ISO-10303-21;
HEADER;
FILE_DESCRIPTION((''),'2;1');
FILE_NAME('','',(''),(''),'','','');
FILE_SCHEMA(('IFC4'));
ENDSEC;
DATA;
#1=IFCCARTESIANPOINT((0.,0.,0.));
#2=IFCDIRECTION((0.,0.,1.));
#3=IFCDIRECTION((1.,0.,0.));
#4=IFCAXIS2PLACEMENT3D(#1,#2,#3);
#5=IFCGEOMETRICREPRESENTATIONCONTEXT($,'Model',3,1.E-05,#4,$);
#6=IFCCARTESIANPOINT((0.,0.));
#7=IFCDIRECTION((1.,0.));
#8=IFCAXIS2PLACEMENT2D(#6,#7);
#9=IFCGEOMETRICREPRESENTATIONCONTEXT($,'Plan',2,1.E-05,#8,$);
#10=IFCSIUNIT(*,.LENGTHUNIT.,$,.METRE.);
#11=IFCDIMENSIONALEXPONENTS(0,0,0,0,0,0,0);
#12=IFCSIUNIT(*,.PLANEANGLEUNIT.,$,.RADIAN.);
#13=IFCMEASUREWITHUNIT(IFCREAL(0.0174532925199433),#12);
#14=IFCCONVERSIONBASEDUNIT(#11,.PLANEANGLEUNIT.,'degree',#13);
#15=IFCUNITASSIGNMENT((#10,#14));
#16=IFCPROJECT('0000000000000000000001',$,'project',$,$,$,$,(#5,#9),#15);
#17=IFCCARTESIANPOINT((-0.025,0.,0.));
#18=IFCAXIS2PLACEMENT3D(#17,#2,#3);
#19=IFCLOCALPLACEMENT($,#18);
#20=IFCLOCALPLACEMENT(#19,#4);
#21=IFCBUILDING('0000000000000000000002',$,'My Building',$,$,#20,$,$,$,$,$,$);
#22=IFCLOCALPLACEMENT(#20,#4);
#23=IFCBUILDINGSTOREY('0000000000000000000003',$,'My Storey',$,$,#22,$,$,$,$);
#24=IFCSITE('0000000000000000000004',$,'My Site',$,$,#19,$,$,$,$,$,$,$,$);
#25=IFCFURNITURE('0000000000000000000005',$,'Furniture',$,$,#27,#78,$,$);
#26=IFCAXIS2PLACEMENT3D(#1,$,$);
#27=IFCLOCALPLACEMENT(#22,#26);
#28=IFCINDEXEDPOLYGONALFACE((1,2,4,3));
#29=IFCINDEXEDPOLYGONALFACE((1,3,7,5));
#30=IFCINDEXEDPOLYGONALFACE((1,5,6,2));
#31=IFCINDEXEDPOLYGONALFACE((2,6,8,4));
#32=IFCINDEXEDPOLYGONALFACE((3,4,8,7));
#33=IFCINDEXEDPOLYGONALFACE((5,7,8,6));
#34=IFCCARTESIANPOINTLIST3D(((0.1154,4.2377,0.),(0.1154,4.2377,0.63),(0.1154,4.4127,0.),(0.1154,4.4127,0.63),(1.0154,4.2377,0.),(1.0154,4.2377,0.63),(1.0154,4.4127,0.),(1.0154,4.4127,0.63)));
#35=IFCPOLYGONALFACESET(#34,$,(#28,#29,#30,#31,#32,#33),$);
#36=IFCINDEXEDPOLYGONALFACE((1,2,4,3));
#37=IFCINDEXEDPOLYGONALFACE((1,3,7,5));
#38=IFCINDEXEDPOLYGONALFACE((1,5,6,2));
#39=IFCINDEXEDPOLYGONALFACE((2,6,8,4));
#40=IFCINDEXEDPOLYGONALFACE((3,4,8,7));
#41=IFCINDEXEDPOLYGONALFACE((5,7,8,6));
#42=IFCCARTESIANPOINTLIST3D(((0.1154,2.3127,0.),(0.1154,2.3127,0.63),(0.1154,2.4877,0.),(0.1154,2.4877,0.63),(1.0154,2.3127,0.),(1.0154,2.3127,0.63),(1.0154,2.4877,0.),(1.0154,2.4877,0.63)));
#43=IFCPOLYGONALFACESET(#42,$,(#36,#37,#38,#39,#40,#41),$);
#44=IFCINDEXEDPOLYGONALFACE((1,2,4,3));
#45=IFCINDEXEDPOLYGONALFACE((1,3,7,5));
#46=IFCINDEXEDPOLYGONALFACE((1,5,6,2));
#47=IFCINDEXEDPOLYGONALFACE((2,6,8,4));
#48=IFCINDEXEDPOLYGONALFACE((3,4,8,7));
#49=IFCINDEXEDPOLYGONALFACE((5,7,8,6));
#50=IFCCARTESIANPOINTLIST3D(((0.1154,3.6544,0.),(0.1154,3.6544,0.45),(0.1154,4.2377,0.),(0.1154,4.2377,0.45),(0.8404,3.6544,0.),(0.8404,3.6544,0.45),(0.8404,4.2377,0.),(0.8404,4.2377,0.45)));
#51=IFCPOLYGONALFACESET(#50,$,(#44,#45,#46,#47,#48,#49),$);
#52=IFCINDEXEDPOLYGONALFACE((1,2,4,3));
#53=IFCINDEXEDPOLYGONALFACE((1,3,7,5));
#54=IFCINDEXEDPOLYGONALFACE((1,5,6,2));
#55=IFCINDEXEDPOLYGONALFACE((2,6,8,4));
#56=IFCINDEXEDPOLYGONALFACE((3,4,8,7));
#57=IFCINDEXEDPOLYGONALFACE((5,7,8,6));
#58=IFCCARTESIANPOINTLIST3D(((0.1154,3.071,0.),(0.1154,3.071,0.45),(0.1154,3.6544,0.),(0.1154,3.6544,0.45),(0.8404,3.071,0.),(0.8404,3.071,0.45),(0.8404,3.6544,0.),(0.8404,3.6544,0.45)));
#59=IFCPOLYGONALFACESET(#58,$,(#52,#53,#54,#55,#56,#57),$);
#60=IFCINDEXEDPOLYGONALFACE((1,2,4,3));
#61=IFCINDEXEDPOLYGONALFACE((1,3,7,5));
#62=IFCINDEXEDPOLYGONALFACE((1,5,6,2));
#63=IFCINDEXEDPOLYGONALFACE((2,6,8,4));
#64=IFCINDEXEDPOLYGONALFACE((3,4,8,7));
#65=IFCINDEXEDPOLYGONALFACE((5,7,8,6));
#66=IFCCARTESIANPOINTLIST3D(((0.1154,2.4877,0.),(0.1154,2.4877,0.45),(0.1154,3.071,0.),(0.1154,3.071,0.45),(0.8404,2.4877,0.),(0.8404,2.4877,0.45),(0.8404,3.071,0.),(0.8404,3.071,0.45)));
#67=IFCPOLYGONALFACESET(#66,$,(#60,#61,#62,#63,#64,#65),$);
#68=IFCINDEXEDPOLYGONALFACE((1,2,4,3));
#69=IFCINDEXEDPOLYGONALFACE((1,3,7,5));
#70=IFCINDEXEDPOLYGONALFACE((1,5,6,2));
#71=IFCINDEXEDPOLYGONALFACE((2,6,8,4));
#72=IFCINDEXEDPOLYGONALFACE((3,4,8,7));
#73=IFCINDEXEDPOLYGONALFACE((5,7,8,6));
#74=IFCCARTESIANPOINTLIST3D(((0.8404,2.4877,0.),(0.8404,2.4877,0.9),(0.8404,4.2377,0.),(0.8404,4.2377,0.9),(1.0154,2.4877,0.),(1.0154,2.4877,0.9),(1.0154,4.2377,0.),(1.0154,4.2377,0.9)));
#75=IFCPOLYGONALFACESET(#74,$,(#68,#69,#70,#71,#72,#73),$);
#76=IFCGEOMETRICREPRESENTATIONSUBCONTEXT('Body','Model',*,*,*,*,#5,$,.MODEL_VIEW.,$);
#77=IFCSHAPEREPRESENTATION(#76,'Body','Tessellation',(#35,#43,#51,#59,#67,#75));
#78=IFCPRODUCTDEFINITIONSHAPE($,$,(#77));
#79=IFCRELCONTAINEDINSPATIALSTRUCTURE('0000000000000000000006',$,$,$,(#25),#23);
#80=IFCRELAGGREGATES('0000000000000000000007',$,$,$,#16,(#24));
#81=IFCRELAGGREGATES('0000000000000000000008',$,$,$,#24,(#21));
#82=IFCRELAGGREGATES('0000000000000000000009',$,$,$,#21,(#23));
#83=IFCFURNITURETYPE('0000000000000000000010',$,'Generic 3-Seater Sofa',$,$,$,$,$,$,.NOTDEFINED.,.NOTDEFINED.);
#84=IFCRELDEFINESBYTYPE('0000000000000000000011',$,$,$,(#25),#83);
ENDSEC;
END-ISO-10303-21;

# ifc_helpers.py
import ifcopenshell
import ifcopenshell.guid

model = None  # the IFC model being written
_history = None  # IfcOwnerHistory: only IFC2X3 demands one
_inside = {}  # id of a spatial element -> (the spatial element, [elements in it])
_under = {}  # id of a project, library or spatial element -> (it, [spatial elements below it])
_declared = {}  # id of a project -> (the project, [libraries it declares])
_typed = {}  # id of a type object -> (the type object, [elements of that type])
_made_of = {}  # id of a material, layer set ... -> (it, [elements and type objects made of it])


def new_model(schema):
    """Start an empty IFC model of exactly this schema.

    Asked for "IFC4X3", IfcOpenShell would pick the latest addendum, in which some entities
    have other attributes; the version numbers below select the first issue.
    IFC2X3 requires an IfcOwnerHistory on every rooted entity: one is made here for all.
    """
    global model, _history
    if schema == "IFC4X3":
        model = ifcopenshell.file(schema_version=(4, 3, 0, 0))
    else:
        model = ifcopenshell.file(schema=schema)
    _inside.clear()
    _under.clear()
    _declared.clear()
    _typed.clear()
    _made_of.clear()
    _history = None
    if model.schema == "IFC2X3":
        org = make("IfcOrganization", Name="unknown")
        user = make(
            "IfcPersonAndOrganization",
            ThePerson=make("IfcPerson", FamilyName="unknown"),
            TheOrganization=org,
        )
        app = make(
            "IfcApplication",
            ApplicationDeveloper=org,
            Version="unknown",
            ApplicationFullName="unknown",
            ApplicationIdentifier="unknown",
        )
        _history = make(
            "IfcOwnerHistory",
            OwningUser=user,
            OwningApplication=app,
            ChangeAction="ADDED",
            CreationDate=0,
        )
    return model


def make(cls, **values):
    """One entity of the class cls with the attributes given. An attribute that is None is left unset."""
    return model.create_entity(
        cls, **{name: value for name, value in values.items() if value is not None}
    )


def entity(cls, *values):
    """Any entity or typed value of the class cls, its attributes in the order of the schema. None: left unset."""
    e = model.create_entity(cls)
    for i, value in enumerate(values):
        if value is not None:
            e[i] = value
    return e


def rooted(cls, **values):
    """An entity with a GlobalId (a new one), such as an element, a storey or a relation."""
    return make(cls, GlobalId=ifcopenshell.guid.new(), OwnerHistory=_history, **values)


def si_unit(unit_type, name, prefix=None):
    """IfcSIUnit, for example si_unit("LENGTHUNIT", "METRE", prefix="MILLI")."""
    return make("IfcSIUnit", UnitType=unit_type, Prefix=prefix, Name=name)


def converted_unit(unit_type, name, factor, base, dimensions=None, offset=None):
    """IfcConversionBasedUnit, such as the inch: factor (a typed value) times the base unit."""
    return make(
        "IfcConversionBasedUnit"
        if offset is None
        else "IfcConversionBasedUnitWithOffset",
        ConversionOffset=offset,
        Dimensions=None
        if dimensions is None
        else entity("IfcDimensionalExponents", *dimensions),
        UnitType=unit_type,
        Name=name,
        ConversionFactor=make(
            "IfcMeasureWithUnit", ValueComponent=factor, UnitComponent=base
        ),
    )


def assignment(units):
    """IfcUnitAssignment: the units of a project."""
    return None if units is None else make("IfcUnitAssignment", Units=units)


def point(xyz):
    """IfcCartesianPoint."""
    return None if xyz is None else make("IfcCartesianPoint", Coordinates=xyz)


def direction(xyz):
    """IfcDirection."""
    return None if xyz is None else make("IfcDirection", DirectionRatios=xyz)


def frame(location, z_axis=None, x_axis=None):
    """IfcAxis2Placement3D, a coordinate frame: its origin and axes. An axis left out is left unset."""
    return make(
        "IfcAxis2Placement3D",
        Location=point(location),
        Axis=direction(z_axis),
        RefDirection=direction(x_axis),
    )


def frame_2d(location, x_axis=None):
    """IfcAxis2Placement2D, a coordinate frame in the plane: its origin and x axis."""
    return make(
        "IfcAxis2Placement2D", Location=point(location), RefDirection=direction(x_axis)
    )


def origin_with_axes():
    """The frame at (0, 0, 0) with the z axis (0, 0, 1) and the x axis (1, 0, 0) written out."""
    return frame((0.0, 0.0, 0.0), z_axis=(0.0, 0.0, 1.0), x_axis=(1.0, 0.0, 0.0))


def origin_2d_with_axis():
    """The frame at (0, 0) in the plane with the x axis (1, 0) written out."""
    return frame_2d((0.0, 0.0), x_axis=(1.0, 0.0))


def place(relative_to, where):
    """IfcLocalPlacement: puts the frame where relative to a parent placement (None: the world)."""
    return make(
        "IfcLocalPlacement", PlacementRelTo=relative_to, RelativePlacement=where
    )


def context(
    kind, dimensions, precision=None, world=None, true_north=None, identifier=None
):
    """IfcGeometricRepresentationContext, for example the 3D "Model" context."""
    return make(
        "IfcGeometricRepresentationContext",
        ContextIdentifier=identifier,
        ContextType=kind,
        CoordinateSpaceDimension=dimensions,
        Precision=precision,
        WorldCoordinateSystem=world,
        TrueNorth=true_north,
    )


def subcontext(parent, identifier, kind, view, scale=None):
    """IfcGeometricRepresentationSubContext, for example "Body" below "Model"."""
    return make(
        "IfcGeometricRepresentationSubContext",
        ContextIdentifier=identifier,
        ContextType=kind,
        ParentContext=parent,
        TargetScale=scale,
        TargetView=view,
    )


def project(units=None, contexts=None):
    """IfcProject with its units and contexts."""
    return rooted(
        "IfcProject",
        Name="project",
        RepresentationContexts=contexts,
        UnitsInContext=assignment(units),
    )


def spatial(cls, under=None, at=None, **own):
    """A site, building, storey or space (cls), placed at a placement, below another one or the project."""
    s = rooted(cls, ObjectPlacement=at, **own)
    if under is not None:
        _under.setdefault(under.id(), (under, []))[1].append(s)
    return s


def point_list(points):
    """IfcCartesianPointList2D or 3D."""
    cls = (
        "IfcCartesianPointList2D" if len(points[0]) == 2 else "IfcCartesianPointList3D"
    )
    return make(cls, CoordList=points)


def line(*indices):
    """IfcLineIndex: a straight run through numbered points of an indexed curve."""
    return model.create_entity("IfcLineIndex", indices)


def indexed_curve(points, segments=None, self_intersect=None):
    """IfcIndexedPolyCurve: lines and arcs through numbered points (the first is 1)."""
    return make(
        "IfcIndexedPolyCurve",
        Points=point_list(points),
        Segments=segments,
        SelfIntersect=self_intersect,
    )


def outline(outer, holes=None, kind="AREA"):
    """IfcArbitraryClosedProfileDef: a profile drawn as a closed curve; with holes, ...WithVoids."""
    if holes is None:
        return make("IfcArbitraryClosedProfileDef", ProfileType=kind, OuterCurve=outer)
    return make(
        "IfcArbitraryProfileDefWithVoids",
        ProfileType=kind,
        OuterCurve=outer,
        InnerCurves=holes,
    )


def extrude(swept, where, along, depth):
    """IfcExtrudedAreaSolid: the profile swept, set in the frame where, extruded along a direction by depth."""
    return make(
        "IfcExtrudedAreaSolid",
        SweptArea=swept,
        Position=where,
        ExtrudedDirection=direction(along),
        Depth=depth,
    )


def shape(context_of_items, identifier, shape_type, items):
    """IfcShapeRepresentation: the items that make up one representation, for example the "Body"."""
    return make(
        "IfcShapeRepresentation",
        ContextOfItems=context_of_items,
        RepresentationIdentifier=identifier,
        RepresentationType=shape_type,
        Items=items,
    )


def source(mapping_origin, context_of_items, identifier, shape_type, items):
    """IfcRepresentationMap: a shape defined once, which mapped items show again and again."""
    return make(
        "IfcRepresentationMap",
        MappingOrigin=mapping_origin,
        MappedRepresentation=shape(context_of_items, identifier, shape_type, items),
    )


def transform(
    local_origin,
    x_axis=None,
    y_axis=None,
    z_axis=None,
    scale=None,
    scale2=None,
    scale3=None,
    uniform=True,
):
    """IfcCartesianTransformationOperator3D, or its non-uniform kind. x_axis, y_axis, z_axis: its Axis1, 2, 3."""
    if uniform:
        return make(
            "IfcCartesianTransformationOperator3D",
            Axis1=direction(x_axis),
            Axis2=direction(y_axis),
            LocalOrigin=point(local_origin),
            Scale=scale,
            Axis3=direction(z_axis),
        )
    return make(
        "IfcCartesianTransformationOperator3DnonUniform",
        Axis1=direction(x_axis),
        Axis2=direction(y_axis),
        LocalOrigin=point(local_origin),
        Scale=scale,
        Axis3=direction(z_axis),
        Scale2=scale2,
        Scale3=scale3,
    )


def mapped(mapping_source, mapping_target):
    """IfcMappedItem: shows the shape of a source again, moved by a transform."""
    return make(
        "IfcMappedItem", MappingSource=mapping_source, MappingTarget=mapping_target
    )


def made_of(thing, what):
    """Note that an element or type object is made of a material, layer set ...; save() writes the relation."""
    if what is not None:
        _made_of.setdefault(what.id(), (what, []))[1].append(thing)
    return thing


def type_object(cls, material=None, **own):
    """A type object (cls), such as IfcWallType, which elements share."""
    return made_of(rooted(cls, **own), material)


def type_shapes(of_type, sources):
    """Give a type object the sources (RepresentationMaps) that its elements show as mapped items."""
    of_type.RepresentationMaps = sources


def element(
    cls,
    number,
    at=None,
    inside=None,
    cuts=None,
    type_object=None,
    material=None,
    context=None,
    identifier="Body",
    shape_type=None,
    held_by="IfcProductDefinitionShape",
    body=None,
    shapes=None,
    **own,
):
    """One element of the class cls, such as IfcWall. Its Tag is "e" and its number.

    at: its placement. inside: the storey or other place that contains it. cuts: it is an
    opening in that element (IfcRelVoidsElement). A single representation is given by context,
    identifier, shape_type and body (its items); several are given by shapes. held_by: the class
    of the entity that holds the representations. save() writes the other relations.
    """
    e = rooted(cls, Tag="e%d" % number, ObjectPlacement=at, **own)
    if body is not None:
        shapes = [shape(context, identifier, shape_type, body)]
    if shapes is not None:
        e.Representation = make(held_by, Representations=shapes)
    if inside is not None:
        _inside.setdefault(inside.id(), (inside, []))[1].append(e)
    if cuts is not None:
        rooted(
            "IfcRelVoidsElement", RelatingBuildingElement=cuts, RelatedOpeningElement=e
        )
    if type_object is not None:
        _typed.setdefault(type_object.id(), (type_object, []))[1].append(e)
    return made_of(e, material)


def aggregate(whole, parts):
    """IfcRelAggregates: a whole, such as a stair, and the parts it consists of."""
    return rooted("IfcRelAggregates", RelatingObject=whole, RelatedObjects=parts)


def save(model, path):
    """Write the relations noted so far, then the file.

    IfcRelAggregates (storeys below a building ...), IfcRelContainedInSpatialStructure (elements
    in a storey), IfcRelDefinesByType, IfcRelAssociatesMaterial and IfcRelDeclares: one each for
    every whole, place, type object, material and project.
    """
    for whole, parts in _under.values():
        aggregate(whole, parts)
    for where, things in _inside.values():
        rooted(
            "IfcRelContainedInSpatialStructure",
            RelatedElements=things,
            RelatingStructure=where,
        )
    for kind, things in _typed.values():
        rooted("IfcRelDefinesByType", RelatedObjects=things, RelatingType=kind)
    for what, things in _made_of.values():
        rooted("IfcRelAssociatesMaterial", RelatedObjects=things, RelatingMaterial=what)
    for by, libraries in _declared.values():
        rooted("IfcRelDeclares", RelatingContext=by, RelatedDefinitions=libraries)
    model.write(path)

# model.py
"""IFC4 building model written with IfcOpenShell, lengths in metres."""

from ifc_helpers import new_model, entity, si_unit, converted_unit, frame, origin_with_axes, origin_2d_with_axis, place, context, subcontext, project, spatial, line, indexed_curve, outline, extrude, shape, source, transform, mapped, type_object, type_shapes, element, save


model = new_model("IFC4")

# Units and contexts
model_context = context("Model", 3, precision=1e-05, world=origin_with_axes())
plan_context = context("Plan", 2, precision=1e-05, world=origin_2d_with_axis())
body_context_1 = subcontext(model_context, "Body", "Model", "MODEL_VIEW")
body_context_2 = subcontext(plan_context, "Body", "Plan", "PLAN_VIEW")
ifc_project = project(units=[si_unit("LENGTHUNIT", "METRE"), converted_unit("PLANEANGLEUNIT", "degree", entity("IfcReal", 0.0174532925199433), si_unit("PLANEANGLEUNIT", "RADIAN"), dimensions=[0, 0, 0, 0, 0, 0, 0])], contexts=[model_context, plan_context])

# Site, building, storey
site_placement = place(None, frame((-0.025, 0.0, 0.0), z_axis=(0.0, 0.0, 1.0), x_axis=(1.0, 0.0, 0.0)))
site = spatial("IfcSite", under=ifc_project, at=site_placement, Name="My Site")
building_placement = place(site_placement, origin_with_axes())
building = spatial("IfcBuilding", under=site, at=building_placement, Name="My Building")
storey_placement = place(building_placement, origin_with_axes())
storey = spatial("IfcBuildingStorey", under=building, at=storey_placement, Name="My Storey")

# Furniture
furniture_type_1 = type_object("IfcFurnitureType", Name="Generic 3-Seater Sofa", AssemblyPlace="NOTDEFINED", PredefinedType="NOTDEFINED")
shared_shape_1 = source(origin_with_axes(), body_context_1, "Body", "SweptSolid", [
    extrude(outline(indexed_curve([(0.0, 0.0), (0.175, 0.0), (0.175, 0.9), (0.0, 0.9)], segments=[line(1, 2, 3, 4, 1)])), frame((-1.05, -0.9, 0.0), z_axis=(0.0, 0.0, 1.0), x_axis=(1.0, 0.0, 0.0)), (0.0, 0.0, 1.0), 0.63),
    extrude(outline(indexed_curve([(0.0, 0.0), (0.175, 0.0), (0.175, 0.9), (0.0, 0.9)], segments=[line(1, 2, 3, 4, 1)])), frame((0.875, -0.9, 0.0), z_axis=(0.0, 0.0, 1.0), x_axis=(1.0, 0.0, 0.0)), (0.0, 0.0, 1.0), 0.63),
    extrude(outline(indexed_curve([(0.175, 0.0), (0.7583, 0.0), (0.7583, 0.725), (0.175, 0.725)], segments=[line(1, 2, 3, 4, 1)])), frame((-1.05, -0.9, 0.0), z_axis=(0.0, 0.0, 1.0), x_axis=(1.0, 0.0, 0.0)), (0.0, 0.0, 1.0), 0.45),
    extrude(outline(indexed_curve([(0.7583, 0.0), (1.3417, 0.0), (1.3417, 0.725), (0.7583, 0.725)], segments=[line(1, 2, 3, 4, 1)])), frame((-1.05, -0.9, 0.0), z_axis=(0.0, 0.0, 1.0), x_axis=(1.0, 0.0, 0.0)), (0.0, 0.0, 1.0), 0.45),
    extrude(outline(indexed_curve([(1.3417, 0.0), (1.925, 0.0), (1.925, 0.725), (1.3417, 0.725)], segments=[line(1, 2, 3, 4, 1)])), frame((-1.05, -0.9, 0.0), z_axis=(0.0, 0.0, 1.0), x_axis=(1.0, 0.0, 0.0)), (0.0, 0.0, 1.0), 0.45),
    extrude(outline(indexed_curve([(0.175, 0.725), (1.925, 0.725), (1.925, 0.9), (0.175, 0.9)], segments=[line(1, 2, 3, 4, 1)])), frame((-1.05, -0.9, 0.0), z_axis=(0.0, 0.0, 1.0), x_axis=(1.0, 0.0, 0.0)), (0.0, 0.0, 1.0), 0.9),
])
shared_shape_2 = source(origin_with_axes(), body_context_2, "Body", "Curve2D", [
    entity("IfcIndexedPolyCurve", entity("IfcCartesianPointList2D", [[-1.05, -0.9], [-0.875, -0.9], [-0.875, 0.0], [-1.05, 0.0]]), [entity("IfcLineIndex", [1, 2, 3, 4, 1])]),
    entity("IfcIndexedPolyCurve", entity("IfcCartesianPointList2D", [[0.875, -0.9], [1.05, -0.9], [1.05, 0.0], [0.875, 0.0]]), [entity("IfcLineIndex", [1, 2, 3, 4, 1])]),
    entity("IfcIndexedPolyCurve", entity("IfcCartesianPointList2D", [[-0.875, -0.9], [-0.2917, -0.9], [-0.2917, -0.175], [-0.875, -0.175]]), [entity("IfcLineIndex", [1, 2, 3, 4, 1])]),
    entity("IfcIndexedPolyCurve", entity("IfcCartesianPointList2D", [[-0.2917, -0.9], [0.2917, -0.9], [0.2917, -0.175], [-0.2917, -0.175]]), [entity("IfcLineIndex", [1, 2, 3, 4, 1])]),
    entity("IfcIndexedPolyCurve", entity("IfcCartesianPointList2D", [[0.2917, -0.9], [0.875, -0.9], [0.875, -0.175], [0.2917, -0.175]]), [entity("IfcLineIndex", [1, 2, 3, 4, 1])]),
    entity("IfcIndexedPolyCurve", entity("IfcCartesianPointList2D", [[-0.875, -0.175], [0.875, -0.175], [0.875, 0.0], [-0.875, 0.0]]), [entity("IfcLineIndex", [1, 2, 3, 4, 1])]),
])
type_shapes(furniture_type_1, [shared_shape_1, shared_shape_2])
furniture_1_placement = place(storey_placement, frame((1.0154, 3.3627, 0.0), z_axis=(0.0, 0.0, 1.0), x_axis=(0.0, -1.0, 0.0)))
element("IfcFurniture", 1, at=furniture_1_placement, inside=storey, type_object=furniture_type_1, Name="Furniture", shapes=[
    shape(body_context_1, "Body", "MappedRepresentation", [mapped(shared_shape_1, transform((0.0, 0.0, 0.0), x_axis=(1.0, 0.0, 0.0), y_axis=(0.0, 1.0, 0.0), z_axis=(0.0, 0.0, 1.0), scale=1.0))]),
    shape(body_context_2, "Body", "MappedRepresentation", [mapped(shared_shape_2, transform((0.0, 0.0, 0.0), x_axis=(1.0, 0.0, 0.0), y_axis=(0.0, 1.0, 0.0), z_axis=(0.0, 0.0, 1.0), scale=1.0))]),
])

save(model, "model.ifc")
